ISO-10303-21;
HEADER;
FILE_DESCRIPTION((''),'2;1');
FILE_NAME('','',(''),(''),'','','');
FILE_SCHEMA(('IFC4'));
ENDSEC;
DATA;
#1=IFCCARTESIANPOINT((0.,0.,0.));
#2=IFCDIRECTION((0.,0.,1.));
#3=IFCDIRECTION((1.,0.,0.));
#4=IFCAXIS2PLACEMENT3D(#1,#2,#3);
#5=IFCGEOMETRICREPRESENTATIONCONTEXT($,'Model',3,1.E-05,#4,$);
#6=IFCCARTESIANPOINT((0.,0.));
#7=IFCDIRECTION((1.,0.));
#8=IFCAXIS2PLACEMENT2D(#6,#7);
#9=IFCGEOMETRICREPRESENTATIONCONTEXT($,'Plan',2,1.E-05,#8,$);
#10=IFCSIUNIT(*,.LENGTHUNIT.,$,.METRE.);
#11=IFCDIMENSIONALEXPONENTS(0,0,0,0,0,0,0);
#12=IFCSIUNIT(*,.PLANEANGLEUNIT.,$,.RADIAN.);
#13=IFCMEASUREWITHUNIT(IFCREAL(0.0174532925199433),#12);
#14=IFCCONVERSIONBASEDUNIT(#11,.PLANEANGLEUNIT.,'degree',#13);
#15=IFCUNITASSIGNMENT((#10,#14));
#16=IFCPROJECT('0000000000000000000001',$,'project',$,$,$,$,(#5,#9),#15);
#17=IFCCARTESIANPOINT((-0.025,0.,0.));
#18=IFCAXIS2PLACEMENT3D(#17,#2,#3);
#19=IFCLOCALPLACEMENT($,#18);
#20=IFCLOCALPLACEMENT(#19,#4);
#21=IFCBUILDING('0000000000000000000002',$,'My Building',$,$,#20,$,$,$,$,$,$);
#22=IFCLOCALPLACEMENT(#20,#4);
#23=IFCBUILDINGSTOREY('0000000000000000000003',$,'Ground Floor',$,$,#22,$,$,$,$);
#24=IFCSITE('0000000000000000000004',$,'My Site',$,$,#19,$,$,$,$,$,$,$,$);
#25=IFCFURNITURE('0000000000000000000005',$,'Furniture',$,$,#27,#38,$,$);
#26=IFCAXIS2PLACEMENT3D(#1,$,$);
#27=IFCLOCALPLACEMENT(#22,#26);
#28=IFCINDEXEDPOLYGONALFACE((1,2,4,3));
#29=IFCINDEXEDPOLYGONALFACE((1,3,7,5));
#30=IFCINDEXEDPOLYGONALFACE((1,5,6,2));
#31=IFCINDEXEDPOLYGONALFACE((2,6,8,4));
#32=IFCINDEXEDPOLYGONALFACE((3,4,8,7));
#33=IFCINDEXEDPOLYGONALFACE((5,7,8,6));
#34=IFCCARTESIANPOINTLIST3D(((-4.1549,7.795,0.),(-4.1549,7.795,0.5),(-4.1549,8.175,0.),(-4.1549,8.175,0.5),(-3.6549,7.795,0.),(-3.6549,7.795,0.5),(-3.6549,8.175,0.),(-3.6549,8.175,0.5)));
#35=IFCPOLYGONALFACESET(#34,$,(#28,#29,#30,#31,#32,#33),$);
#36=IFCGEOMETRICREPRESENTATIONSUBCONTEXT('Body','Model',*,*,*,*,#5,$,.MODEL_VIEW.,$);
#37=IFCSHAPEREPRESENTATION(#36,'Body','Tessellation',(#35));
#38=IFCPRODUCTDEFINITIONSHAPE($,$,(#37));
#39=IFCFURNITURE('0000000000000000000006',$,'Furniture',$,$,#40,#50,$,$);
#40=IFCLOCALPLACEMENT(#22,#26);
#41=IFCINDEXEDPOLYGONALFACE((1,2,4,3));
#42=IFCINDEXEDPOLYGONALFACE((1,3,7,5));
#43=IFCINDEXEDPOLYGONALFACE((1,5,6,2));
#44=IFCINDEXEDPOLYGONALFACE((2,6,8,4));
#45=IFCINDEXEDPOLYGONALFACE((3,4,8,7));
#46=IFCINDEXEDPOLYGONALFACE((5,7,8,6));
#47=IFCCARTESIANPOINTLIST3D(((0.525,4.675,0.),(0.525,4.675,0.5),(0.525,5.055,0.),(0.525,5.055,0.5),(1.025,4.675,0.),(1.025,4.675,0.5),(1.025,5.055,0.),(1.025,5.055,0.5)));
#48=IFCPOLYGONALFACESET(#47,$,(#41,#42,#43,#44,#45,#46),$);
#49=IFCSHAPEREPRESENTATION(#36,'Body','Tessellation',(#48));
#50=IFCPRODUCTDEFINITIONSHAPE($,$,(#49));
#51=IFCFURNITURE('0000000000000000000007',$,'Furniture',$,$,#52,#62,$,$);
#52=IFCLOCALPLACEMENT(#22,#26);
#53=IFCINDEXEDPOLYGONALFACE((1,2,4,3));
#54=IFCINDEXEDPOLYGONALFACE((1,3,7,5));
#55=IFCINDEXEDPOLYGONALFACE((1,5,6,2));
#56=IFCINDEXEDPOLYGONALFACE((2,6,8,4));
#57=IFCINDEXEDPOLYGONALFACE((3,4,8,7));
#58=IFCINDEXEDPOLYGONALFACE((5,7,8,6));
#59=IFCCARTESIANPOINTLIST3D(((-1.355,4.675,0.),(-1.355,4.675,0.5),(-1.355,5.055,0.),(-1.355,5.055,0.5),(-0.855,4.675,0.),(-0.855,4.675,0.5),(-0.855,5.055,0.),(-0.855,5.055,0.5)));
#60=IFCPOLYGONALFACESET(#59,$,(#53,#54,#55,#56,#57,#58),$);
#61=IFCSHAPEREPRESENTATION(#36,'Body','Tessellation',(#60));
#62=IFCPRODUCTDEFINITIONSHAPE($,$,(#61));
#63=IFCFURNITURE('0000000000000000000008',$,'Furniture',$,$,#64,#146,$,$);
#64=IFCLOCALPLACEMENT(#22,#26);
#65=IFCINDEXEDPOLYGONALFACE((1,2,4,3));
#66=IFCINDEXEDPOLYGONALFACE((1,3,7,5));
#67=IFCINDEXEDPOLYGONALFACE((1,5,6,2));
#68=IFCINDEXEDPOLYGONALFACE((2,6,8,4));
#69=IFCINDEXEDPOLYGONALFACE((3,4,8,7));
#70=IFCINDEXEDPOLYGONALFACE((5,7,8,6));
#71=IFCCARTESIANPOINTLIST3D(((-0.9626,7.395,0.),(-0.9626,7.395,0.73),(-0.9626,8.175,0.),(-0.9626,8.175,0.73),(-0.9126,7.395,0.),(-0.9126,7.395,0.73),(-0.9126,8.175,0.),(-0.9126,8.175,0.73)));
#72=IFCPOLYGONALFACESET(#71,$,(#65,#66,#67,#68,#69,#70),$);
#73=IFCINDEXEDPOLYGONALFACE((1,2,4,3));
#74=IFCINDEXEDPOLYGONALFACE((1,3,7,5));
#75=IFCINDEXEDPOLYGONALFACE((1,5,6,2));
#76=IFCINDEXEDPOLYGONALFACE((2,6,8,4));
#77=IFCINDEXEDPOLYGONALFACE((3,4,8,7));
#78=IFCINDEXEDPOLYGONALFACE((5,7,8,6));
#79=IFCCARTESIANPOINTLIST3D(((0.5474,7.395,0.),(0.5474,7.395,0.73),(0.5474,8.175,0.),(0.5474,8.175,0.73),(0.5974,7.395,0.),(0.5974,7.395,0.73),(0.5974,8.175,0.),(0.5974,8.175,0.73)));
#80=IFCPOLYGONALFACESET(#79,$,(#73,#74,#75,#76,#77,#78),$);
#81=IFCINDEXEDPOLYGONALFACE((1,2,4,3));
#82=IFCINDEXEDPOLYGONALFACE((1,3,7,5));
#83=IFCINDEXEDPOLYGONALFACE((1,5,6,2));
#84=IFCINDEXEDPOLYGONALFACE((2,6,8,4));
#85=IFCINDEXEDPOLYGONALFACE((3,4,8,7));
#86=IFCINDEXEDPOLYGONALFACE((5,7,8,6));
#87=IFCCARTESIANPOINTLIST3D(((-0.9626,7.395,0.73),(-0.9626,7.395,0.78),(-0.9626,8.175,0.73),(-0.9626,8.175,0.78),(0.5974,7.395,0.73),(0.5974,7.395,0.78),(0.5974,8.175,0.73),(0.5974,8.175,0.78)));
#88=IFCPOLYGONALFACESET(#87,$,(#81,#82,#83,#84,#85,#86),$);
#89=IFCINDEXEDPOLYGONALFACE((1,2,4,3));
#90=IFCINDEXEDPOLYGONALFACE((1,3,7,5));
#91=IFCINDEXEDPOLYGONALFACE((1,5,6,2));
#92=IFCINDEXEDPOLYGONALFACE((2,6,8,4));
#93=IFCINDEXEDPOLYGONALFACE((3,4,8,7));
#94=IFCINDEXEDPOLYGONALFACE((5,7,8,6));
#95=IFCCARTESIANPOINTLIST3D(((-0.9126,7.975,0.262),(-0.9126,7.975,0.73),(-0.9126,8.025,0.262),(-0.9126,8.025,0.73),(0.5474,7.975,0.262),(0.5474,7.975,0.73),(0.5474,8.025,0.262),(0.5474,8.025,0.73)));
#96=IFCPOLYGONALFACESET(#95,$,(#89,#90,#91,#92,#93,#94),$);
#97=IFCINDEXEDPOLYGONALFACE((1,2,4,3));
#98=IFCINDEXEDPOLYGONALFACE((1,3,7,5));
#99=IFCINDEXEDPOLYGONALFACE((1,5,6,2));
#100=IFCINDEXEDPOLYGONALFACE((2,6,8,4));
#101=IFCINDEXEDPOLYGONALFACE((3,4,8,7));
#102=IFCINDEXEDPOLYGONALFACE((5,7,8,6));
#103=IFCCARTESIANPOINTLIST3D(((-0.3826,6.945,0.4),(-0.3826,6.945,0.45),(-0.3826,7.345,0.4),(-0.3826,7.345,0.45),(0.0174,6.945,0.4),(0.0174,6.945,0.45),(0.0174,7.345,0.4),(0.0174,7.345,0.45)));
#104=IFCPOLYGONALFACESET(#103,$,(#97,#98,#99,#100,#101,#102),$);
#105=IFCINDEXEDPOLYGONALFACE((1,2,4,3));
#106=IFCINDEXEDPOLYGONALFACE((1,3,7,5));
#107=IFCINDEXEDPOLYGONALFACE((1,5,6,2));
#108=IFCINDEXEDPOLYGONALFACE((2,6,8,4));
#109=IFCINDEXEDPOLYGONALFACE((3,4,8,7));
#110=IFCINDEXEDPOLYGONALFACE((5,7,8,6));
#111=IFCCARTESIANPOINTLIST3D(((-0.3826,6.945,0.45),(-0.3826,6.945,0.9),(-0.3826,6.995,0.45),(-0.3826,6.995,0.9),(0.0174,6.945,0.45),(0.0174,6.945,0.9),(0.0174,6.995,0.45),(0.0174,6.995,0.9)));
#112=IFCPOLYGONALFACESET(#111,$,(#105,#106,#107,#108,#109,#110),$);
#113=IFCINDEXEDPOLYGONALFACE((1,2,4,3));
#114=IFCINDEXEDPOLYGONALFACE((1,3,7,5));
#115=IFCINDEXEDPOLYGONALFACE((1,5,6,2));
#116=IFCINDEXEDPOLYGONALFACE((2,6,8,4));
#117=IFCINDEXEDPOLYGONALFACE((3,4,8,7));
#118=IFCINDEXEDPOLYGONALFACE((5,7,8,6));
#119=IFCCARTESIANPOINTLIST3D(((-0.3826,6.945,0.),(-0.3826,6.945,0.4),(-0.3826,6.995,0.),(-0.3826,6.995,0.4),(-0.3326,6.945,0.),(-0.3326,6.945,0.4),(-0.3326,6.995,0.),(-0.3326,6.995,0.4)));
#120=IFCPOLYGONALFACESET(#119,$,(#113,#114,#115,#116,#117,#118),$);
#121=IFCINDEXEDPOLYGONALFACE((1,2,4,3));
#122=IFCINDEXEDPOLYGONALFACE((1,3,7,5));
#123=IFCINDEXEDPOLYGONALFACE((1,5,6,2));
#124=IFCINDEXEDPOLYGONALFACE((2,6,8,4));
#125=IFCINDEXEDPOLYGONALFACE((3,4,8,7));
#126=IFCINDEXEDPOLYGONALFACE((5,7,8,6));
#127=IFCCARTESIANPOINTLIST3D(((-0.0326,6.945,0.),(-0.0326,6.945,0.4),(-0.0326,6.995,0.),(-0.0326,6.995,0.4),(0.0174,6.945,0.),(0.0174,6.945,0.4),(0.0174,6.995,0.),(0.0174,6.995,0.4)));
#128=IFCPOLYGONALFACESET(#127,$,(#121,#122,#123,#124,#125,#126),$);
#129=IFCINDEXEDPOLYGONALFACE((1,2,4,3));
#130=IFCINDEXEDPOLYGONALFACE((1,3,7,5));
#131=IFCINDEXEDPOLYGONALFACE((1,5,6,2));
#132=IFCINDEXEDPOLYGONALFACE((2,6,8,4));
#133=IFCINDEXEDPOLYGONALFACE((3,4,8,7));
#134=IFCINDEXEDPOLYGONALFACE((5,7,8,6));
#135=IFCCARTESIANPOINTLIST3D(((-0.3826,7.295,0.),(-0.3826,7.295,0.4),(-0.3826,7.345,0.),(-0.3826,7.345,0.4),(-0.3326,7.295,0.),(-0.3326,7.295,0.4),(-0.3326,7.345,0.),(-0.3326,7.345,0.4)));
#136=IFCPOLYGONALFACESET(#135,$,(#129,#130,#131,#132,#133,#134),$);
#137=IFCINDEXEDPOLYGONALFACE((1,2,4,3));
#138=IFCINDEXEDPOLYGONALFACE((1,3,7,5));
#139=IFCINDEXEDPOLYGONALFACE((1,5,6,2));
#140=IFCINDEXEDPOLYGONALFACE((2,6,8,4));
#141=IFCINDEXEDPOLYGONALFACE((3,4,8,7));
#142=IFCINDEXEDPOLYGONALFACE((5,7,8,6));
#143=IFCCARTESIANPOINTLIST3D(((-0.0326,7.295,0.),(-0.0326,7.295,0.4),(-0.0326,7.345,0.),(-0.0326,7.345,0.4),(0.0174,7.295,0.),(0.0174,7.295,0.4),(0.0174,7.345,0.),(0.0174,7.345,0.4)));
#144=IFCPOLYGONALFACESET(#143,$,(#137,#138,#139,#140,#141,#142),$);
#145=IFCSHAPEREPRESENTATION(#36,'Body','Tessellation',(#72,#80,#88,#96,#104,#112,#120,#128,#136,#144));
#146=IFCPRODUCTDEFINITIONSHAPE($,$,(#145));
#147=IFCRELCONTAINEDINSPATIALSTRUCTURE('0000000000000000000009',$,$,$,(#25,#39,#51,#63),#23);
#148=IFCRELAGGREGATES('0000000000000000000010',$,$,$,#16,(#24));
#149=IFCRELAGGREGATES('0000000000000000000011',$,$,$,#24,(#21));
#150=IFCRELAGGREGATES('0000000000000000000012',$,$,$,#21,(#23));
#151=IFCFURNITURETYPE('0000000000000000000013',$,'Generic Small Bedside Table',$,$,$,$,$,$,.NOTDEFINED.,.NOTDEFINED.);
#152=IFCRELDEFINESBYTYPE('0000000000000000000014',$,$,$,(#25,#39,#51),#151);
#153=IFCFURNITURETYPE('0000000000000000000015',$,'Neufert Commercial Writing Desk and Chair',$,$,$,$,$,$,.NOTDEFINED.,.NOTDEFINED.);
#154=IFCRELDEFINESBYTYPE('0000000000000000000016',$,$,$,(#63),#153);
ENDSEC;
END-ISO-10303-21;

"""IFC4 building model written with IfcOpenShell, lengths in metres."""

from ifc_helpers import new_model, entity, si_unit, converted_unit, frame, origin_with_axes, origin_2d_with_axis, place, context, subcontext, project, spatial, line, indexed_curve, outline, extrude, shape, source, transform, mapped, type_object, type_shapes, element, save


model = new_model("IFC4")

# Units and contexts
model_context = context("Model", 3, precision=1e-05, world=origin_with_axes())
plan_context = context("Plan", 2, precision=1e-05, world=origin_2d_with_axis())
body_context_1 = subcontext(model_context, "Body", "Model", "MODEL_VIEW")
body_context_2 = subcontext(plan_context, "Body", "Plan", "PLAN_VIEW")
ifc_project = project(units=[si_unit("LENGTHUNIT", "METRE"), converted_unit("PLANEANGLEUNIT", "degree", entity("IfcReal", 0.0174532925199433), si_unit("PLANEANGLEUNIT", "RADIAN"), dimensions=[0, 0, 0, 0, 0, 0, 0])], contexts=[model_context, plan_context])

# Site, building, storey
site_placement = place(None, frame((-0.025, 0.0, 0.0), z_axis=(0.0, 0.0, 1.0), x_axis=(1.0, 0.0, 0.0)))
site = spatial("IfcSite", under=ifc_project, at=site_placement, Name="My Site")
building_placement = place(site_placement, origin_with_axes())
building = spatial("IfcBuilding", under=site, at=building_placement, Name="My Building")
storey_placement = place(building_placement, frame((0.0, 0.0, 0.0), z_axis=(0.0, 0.0, 1.0), x_axis=(1.0, 0.0, 0.0)))
storey = spatial("IfcBuildingStorey", under=building, at=storey_placement, Name="Ground Floor")

# Furniture
furniture_type_1 = type_object("IfcFurnitureType", Name="Generic Small Bedside Table", AssemblyPlace="NOTDEFINED", PredefinedType="NOTDEFINED")
shared_shape_1 = source(origin_with_axes(), body_context_1, "Body", "SweptSolid", [
    extrude(outline(indexed_curve([(0.0, 0.0), (0.5, 0.0), (0.5, 0.38), (0.0, 0.38)], segments=[line(1, 2, 3, 4, 1)])), frame((-0.25, -0.19, 0.0), z_axis=(0.0, 0.0, 1.0), x_axis=(1.0, 0.0, 0.0)), (0.0, 0.0, 1.0), 0.5),
])
shared_shape_2 = source(origin_with_axes(), body_context_2, "Body", "Curve2D", [
    entity("IfcIndexedPolyCurve", entity("IfcCartesianPointList2D", [[-0.25, -0.19], [0.25, -0.19], [0.25, 0.19], [-0.25, 0.19]]), [entity("IfcLineIndex", [1, 2, 3, 4, 1])]),
])
type_shapes(furniture_type_1, [shared_shape_1, shared_shape_2])
for number, where, z_axis, x_axis, name in (
    (1, (-3.9049, 7.985, 0.0), (0.0, 0.0, 1.0), (1.0, 0.0, 0.0), "Furniture"),
    (2, (0.775, 4.865, 0.0), (0.0, 0.0, 1.0), (-1.0, 0.0, 0.0), "Furniture"),
    (3, (-1.105, 4.865, 0.0), (0.0, 0.0, 1.0), (-1.0, 0.0, 0.0), "Furniture"),
):
    element("IfcFurniture", number, at=place(storey_placement, frame(where, z_axis=z_axis, x_axis=x_axis)), inside=storey, type_object=furniture_type_1, Name=name, shapes=[
        shape(body_context_1, "Body", "MappedRepresentation", [mapped(shared_shape_1, transform((0.0, 0.0, 0.0), x_axis=(1.0, 0.0, 0.0), y_axis=(0.0, 1.0, 0.0), z_axis=(0.0, 0.0, 1.0), scale=1.0))]),
        shape(body_context_2, "Body", "MappedRepresentation", [mapped(shared_shape_2, transform((0.0, 0.0, 0.0), x_axis=(1.0, 0.0, 0.0), y_axis=(0.0, 1.0, 0.0), z_axis=(0.0, 0.0, 1.0), scale=1.0))]),
    ])
furniture_type_2 = type_object("IfcFurnitureType", Name="Neufert Commercial Writing Desk and Chair", AssemblyPlace="NOTDEFINED", PredefinedType="NOTDEFINED")
shared_shape_3 = source(origin_with_axes(), body_context_1, "Body", "SweptSolid", [
    extrude(outline(indexed_curve([(0.0, 0.0), (0.05, 0.0), (0.05, 0.78), (0.0, 0.78)], segments=[line(1, 2, 3, 4, 1)])), frame((0.0, 0.45, 0.0), z_axis=(0.0, 0.0, 1.0), x_axis=(1.0, 0.0, 0.0)), (0.0, 0.0, 1.0), 0.73),
    extrude(outline(indexed_curve([(0.0, 0.0), (0.05, 0.0), (0.05, 0.78), (0.0, 0.78)], segments=[line(1, 2, 3, 4, 1)])), frame((1.51, 0.45, 0.0), z_axis=(0.0, 0.0, 1.0), x_axis=(1.0, 0.0, 0.0)), (0.0, 0.0, 1.0), 0.73),
    extrude(outline(indexed_curve([(0.0, 0.0), (1.56, 0.0), (1.56, 0.78), (0.0, 0.78)], segments=[line(1, 2, 3, 4, 1)])), frame((0.0, 0.45, 0.73), z_axis=(0.0, 0.0, 1.0), x_axis=(1.0, 0.0, 0.0)), (0.0, 0.0, 1.0), 0.05),
    extrude(outline(indexed_curve([(0.05, 0.58), (1.51, 0.58), (1.51, 0.63), (0.05, 0.63)], segments=[line(1, 2, 3, 4, 1)])), frame((0.0, 0.45, 0.262), z_axis=(0.0, 0.0, 1.0), x_axis=(1.0, 0.0, 0.0)), (0.0, 0.0, 1.0), 0.468),
    extrude(outline(indexed_curve([(-0.2, 0.0), (0.2, 0.0), (0.2, 0.4), (-0.2, 0.4)], segments=[line(1, 2, 3, 4, 1)])), frame((0.78, 0.0, 0.45), z_axis=(0.0, 0.0, 1.0), x_axis=(1.0, 0.0, 0.0)), (0.0, 0.0, -1.0), 0.05),
    extrude(outline(indexed_curve([(-0.2, 0.0), (0.2, 0.0), (0.2, 0.05), (-0.2, 0.05)], segments=[line(1, 2, 3, 4, 1)])), frame((0.78, 0.0, 0.9), z_axis=(0.0, 0.0, 1.0), x_axis=(1.0, 0.0, 0.0)), (0.0, 0.0, -1.0), 0.45),
    extrude(outline(indexed_curve([(-0.2, 0.0), (-0.15, 0.0), (-0.15, 0.05), (-0.2, 0.05)], segments=[line(1, 2, 3, 4, 1)])), frame((0.78, 0.0, 0.0), z_axis=(0.0, 0.0, 1.0), x_axis=(1.0, 0.0, 0.0)), (0.0, 0.0, 1.0), 0.4),
    extrude(outline(indexed_curve([(0.2, 0.0), (0.15, 0.0), (0.15, 0.05), (0.2, 0.05)], segments=[line(1, 2, 3, 4, 1)])), frame((0.78, 0.0, 0.0), z_axis=(0.0, 0.0, 1.0), x_axis=(1.0, 0.0, 0.0)), (0.0, 0.0, 1.0), 0.4),
    extrude(outline(indexed_curve([(-0.2, 0.4), (-0.15, 0.4), (-0.15, 0.35), (-0.2, 0.35)], segments=[line(1, 2, 3, 4, 1)])), frame((0.78, 0.0, 0.0), z_axis=(0.0, 0.0, 1.0), x_axis=(1.0, 0.0, 0.0)), (0.0, 0.0, 1.0), 0.4),
    extrude(outline(indexed_curve([(0.2, 0.4), (0.15, 0.4), (0.15, 0.35), (0.2, 0.35)], segments=[line(1, 2, 3, 4, 1)])), frame((0.78, 0.0, 0.0), z_axis=(0.0, 0.0, 1.0), x_axis=(1.0, 0.0, 0.0)), (0.0, 0.0, 1.0), 0.4),
])
shared_shape_4 = source(origin_with_axes(), body_context_2, "Body", "Curve2D", [
    entity("IfcIndexedPolyCurve", entity("IfcCartesianPointList2D", [[0.0, 0.45], [1.56, 0.45], [1.56, 1.23], [0.0, 1.23]]), [entity("IfcLineIndex", [1, 2, 3, 4, 1])]),
    entity("IfcIndexedPolyCurve", entity("IfcCartesianPointList2D", [[0.58, 0.4], [0.98, 0.4]])),
    entity("IfcIndexedPolyCurve", entity("IfcCartesianPointList2D", [[0.58, 0.4], [0.58, 0.2], [0.6386, 0.0586], [0.78, 0.0], [0.9214, 0.0586], [0.98, 0.2], [0.98, 0.4]]), [entity("IfcLineIndex", [1, 2]), entity("IfcArcIndex", [2, 3, 4]), entity("IfcArcIndex", [4, 5, 6]), entity("IfcLineIndex", [6, 7])]),
    entity("IfcIndexedPolyCurve", entity("IfcCartesianPointList2D", [[0.62, 0.4], [0.62, 0.2], [0.6669, 0.0869], [0.78, 0.04], [0.8931, 0.0869], [0.94, 0.2], [0.94, 0.4]]), [entity("IfcLineIndex", [1, 2]), entity("IfcArcIndex", [2, 3, 4]), entity("IfcArcIndex", [4, 5, 6]), entity("IfcLineIndex", [6, 7])]),
])
type_shapes(furniture_type_2, [shared_shape_3, shared_shape_4])
for number, where, z_axis, x_axis, name in (
    (4, (-0.9626, 6.945, 0.0), (0.0, 0.0, 1.0), (1.0, 0.0, 0.0), "Furniture"),
):
    element("IfcFurniture", number, at=place(storey_placement, frame(where, z_axis=z_axis, x_axis=x_axis)), inside=storey, type_object=furniture_type_2, Name=name, shapes=[
        shape(body_context_1, "Body", "MappedRepresentation", [mapped(shared_shape_3, transform((0.0, 0.0, 0.0), x_axis=(1.0, 0.0, 0.0), y_axis=(0.0, 1.0, 0.0), z_axis=(0.0, 0.0, 1.0), scale=1.0))]),
        shape(body_context_2, "Body", "MappedRepresentation", [mapped(shared_shape_4, transform((0.0, 0.0, 0.0), x_axis=(1.0, 0.0, 0.0), y_axis=(0.0, 1.0, 0.0), z_axis=(0.0, 0.0, 1.0), scale=1.0))]),
    ])

save(model, "model.ifc")
